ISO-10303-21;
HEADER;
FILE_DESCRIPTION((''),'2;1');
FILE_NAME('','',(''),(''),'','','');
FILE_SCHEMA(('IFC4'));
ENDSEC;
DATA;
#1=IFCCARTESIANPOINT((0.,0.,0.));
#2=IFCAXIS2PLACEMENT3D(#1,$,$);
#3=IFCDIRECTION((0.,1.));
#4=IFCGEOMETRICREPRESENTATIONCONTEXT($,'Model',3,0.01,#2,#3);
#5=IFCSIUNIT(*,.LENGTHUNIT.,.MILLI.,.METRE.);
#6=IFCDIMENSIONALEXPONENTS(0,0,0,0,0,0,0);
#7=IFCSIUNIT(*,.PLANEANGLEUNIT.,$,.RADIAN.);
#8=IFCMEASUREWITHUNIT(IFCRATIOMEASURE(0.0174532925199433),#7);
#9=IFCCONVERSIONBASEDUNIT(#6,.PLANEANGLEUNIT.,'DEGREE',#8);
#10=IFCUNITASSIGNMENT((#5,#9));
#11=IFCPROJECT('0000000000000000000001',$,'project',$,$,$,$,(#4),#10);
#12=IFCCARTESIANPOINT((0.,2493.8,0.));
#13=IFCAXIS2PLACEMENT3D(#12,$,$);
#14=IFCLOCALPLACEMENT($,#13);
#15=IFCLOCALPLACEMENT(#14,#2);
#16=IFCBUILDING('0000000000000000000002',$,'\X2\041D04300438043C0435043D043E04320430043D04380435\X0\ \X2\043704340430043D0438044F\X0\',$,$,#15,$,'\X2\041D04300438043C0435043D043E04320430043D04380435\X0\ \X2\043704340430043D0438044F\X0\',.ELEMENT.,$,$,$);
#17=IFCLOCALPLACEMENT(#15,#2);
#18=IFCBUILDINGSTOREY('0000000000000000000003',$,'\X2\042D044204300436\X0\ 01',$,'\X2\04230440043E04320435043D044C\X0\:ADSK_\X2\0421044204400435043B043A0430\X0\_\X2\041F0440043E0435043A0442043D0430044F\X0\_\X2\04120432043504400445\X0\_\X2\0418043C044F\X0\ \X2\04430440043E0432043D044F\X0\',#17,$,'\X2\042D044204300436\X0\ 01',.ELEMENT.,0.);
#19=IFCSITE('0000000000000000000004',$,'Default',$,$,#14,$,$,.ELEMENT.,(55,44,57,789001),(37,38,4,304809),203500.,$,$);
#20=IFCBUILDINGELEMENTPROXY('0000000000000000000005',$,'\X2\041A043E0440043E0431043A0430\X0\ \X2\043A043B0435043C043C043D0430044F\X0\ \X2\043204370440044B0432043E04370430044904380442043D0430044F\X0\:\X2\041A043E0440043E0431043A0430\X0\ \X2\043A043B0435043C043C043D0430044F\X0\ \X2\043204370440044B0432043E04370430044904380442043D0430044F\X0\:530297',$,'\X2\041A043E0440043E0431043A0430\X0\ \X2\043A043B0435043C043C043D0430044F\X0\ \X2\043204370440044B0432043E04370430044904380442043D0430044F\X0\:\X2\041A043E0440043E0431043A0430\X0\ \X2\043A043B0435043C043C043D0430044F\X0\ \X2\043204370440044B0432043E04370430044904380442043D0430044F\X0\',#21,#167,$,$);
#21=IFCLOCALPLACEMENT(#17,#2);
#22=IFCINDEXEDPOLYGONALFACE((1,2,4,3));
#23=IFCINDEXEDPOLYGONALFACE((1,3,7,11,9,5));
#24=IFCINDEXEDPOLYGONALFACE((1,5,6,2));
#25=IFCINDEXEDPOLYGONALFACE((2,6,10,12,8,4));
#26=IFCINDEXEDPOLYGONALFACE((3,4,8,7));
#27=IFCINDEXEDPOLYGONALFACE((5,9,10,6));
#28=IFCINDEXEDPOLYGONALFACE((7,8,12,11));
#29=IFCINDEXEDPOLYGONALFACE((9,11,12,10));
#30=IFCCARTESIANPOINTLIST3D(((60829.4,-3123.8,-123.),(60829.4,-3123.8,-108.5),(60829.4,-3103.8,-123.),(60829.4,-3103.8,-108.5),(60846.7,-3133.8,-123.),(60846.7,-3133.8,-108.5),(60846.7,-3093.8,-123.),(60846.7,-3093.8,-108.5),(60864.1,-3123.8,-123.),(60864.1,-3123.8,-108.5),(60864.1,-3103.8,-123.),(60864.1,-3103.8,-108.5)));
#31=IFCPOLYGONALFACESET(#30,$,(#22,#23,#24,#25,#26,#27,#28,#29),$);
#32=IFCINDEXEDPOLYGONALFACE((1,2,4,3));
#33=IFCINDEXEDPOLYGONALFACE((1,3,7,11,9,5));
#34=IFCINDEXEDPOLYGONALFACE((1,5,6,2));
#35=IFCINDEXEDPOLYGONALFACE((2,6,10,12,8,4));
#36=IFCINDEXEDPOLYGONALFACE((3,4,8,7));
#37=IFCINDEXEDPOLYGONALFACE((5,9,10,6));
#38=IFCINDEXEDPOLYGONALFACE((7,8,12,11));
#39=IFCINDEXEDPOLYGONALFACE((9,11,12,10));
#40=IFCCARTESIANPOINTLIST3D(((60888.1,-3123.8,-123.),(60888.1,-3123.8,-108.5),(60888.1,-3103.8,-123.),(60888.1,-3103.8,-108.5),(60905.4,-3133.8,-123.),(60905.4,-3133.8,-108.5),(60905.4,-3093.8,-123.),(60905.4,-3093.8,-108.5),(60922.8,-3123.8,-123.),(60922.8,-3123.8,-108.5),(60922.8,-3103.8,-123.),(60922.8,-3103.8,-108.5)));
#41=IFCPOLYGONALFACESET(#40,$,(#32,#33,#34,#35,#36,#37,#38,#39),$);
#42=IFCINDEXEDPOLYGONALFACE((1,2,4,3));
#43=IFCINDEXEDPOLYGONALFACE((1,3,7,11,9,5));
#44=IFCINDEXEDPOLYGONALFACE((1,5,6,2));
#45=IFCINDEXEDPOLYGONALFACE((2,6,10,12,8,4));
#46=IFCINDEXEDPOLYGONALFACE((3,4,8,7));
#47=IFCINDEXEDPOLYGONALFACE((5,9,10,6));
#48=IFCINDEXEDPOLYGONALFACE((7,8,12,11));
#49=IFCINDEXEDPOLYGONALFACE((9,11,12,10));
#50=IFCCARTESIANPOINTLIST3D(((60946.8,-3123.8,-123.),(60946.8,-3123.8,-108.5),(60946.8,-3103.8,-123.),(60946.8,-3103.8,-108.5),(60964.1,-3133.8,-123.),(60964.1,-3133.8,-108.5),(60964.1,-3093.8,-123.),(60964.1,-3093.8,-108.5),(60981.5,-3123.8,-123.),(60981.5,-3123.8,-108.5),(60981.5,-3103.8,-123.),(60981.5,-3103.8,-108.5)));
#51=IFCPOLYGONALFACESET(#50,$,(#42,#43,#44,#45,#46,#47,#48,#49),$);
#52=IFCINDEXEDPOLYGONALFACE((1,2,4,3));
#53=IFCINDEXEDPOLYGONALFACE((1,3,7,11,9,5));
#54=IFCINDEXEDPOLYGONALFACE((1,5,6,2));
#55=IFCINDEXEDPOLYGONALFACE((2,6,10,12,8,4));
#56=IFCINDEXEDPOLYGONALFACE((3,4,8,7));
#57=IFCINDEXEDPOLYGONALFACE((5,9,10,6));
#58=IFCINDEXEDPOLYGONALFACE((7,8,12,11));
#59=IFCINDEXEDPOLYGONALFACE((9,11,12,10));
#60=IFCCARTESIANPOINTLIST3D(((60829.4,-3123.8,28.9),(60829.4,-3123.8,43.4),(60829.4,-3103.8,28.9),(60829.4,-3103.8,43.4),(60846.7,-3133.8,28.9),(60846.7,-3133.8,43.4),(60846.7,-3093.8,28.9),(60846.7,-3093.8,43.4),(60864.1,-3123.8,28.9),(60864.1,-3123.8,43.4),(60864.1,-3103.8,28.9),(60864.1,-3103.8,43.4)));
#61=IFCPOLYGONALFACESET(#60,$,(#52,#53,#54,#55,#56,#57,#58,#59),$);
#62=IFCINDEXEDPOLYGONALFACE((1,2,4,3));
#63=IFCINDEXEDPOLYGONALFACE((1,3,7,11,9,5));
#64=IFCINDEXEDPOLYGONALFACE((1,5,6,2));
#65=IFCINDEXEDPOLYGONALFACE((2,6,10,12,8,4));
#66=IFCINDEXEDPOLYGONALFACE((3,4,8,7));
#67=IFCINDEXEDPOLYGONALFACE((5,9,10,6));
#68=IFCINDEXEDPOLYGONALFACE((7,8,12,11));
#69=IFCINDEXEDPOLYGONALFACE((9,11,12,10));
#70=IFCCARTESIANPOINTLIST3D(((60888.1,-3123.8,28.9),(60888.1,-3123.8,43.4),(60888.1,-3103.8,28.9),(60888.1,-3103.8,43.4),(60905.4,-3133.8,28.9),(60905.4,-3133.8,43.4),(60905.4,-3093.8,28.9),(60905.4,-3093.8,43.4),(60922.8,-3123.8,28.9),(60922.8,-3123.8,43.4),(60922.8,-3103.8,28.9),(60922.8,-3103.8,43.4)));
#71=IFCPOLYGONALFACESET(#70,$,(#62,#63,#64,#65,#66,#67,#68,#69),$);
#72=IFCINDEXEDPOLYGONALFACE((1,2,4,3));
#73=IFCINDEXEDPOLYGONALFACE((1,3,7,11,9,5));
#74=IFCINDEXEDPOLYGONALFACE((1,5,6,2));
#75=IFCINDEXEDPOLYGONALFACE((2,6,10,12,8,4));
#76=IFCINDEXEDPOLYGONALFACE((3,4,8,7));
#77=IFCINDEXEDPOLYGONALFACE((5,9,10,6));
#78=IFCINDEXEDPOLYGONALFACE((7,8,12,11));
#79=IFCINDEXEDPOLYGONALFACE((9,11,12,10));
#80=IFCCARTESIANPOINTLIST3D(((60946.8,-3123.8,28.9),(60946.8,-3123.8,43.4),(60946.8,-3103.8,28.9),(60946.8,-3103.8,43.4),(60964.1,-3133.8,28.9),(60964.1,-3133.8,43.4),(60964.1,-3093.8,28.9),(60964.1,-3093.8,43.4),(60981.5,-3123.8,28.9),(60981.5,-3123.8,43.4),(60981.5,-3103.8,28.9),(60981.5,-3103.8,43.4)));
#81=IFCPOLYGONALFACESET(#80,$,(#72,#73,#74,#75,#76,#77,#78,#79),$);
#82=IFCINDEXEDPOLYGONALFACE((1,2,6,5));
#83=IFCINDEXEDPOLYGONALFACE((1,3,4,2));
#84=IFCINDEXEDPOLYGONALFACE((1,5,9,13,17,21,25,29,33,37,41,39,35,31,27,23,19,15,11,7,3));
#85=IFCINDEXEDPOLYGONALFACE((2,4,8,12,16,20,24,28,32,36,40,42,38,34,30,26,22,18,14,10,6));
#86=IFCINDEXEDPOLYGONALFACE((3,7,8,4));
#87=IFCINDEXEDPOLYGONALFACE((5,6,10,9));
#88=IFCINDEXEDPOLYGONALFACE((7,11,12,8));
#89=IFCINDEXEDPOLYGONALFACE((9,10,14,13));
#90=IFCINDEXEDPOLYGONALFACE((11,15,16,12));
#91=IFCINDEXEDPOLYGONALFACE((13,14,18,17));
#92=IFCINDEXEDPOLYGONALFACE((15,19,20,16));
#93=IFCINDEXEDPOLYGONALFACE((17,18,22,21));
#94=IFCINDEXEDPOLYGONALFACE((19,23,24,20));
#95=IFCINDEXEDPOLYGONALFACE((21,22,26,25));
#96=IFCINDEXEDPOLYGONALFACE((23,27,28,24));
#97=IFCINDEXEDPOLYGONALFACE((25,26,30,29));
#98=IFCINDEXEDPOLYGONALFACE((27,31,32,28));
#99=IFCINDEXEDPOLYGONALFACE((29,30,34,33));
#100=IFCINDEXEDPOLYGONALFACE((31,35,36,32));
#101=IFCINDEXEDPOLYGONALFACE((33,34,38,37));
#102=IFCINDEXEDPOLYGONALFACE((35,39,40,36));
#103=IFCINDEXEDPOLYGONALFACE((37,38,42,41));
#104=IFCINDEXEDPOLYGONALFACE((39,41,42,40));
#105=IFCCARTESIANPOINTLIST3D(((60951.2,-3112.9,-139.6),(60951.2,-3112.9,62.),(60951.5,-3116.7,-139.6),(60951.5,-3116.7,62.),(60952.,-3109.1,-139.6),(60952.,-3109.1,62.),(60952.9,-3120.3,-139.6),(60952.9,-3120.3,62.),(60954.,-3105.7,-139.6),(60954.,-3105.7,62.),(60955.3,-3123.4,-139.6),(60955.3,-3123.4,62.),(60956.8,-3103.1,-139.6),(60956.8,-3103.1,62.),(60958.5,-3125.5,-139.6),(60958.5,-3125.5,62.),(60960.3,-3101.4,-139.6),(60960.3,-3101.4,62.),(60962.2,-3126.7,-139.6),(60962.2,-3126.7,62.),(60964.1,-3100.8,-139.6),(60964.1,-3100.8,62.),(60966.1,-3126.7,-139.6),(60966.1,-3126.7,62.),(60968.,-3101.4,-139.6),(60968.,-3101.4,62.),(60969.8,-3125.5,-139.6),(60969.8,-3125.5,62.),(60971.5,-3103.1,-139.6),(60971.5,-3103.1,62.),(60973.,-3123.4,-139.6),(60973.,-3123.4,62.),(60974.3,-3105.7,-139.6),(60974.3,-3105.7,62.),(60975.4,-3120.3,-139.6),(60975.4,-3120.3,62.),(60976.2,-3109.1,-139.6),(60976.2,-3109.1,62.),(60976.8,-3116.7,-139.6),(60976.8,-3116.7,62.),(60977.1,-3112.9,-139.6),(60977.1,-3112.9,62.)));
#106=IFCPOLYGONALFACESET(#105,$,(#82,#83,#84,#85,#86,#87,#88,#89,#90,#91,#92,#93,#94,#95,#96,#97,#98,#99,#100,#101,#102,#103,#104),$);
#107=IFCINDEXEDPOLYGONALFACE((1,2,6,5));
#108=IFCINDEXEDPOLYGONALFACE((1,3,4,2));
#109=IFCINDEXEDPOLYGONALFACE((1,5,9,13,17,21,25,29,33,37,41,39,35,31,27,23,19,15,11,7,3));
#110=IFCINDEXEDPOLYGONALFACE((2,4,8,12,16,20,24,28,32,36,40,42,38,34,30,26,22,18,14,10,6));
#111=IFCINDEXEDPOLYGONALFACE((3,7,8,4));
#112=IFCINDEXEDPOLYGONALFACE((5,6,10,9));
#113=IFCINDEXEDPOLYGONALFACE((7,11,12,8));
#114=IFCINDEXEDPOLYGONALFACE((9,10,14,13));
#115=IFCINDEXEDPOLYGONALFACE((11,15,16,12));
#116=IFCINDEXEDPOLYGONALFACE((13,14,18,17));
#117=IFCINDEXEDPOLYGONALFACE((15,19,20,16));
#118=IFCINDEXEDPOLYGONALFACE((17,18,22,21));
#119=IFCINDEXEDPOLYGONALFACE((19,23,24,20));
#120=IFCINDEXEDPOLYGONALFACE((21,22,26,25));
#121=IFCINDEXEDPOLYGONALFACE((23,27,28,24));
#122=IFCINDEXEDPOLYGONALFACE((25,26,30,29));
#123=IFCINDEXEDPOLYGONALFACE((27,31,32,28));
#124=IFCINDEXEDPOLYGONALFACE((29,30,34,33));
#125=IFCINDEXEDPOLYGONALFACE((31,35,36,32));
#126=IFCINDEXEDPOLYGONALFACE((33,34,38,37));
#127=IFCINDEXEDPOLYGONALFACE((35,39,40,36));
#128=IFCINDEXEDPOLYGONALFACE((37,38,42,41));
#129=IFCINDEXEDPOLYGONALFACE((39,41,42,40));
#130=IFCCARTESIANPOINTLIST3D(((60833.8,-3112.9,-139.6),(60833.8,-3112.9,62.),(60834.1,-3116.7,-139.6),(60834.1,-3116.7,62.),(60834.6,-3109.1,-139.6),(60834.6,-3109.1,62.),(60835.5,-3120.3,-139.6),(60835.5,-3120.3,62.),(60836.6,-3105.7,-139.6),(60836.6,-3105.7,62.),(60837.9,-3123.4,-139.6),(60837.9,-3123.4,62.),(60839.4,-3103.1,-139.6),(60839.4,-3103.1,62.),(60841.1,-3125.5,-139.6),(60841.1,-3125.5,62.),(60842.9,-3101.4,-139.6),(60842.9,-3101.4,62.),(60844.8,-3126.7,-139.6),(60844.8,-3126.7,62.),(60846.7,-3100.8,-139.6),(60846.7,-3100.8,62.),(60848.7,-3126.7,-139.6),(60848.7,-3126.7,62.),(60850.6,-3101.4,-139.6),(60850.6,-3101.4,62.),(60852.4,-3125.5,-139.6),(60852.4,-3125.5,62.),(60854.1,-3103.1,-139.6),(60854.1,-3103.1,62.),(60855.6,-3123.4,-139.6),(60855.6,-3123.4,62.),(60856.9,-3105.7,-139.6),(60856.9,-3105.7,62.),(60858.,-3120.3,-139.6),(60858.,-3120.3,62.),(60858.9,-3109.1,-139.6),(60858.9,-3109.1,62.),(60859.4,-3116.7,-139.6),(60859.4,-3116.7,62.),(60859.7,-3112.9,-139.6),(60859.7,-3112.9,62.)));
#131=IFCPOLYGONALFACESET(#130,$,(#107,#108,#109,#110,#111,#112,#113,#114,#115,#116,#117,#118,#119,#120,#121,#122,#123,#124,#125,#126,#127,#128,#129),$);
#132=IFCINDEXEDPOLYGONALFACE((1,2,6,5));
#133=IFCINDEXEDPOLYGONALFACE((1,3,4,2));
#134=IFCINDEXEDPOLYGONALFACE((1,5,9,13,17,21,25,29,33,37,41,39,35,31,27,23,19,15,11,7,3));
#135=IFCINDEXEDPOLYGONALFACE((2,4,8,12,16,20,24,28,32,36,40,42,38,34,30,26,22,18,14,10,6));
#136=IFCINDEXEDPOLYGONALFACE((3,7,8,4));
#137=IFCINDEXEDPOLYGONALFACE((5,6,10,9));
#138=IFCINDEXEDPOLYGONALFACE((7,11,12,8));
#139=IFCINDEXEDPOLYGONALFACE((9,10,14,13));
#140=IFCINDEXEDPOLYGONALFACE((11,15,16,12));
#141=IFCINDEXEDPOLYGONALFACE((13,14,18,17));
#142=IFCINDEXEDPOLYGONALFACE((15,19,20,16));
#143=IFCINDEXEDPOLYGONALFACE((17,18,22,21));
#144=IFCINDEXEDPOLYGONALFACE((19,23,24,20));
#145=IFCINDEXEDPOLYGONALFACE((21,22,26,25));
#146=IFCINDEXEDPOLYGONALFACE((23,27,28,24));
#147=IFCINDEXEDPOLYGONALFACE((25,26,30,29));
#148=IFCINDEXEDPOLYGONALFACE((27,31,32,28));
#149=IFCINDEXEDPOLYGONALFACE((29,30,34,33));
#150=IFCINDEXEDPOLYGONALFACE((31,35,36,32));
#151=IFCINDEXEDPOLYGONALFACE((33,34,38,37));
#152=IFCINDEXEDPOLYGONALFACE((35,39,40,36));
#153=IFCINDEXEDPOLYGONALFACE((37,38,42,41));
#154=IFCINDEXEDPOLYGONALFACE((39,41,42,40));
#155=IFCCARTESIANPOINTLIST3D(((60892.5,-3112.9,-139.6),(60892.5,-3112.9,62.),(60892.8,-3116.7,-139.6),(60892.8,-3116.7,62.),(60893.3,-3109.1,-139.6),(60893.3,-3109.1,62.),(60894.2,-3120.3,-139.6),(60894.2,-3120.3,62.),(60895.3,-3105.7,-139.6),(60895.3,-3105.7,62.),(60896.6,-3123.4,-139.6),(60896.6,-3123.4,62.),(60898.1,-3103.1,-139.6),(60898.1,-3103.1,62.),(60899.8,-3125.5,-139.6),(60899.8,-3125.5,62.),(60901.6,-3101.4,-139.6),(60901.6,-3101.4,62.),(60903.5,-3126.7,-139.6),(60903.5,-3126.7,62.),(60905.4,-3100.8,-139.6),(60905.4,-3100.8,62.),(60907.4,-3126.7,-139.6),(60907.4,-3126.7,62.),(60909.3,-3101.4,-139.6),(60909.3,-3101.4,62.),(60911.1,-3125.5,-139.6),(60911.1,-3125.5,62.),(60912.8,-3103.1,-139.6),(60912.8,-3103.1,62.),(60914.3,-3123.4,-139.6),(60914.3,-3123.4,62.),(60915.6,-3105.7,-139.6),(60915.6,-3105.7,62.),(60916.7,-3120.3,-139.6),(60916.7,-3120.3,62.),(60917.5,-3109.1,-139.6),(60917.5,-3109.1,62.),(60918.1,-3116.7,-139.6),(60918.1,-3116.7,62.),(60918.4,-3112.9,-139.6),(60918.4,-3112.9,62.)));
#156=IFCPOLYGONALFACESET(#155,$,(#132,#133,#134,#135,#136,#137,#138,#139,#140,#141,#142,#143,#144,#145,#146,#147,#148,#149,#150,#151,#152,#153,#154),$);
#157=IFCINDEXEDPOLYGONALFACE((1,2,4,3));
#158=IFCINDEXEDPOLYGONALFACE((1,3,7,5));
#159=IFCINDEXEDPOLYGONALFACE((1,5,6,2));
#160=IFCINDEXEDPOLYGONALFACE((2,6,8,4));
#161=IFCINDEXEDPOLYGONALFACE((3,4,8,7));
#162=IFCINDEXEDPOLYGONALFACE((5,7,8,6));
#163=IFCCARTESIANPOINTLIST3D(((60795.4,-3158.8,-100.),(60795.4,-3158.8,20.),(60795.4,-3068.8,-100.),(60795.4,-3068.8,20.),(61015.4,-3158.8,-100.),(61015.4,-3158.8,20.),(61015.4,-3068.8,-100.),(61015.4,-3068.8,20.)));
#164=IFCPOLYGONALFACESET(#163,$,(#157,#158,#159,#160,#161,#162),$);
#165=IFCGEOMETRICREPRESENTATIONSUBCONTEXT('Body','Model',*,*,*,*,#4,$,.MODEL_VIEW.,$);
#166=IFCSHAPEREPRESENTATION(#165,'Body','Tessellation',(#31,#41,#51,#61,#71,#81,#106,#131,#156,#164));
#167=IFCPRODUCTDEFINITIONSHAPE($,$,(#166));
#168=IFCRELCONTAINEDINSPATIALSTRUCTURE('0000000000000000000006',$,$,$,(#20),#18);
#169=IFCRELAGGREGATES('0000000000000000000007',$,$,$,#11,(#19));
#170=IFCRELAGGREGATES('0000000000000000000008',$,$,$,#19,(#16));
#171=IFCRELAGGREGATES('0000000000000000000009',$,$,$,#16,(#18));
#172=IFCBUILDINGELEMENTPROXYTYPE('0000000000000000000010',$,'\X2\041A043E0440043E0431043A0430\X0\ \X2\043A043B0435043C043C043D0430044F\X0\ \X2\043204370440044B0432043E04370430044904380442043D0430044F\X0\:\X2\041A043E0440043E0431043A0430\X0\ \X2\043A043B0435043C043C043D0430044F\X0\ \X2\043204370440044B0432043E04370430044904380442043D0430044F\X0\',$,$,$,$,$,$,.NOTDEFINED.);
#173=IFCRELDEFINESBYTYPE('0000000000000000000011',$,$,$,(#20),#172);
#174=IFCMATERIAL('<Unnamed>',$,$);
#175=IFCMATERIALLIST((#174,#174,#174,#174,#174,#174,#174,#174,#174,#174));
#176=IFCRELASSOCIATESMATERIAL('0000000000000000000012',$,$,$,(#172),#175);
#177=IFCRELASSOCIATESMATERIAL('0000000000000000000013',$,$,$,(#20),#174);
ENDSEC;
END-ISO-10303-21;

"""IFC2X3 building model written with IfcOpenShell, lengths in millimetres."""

from ifc_helpers import new_model, entity, si_unit, converted_unit, direction, frame, frame_2d, origin, place, context, subcontext, project, spatial, polyline, rectangle, circle, outline, extrude, source, transform, mapped, material, material_list, type_object, type_shapes, element, save


model = new_model("IFC2X3")

# Units and contexts
model_context = context("Model", 3, precision=0.01, world=origin(), true_north=direction((0.0, 1.0)))
body_context = subcontext(model_context, "Body", "Model", "MODEL_VIEW")
ifc_project = project(units=[si_unit("LENGTHUNIT", "METRE", prefix="MILLI"), converted_unit("PLANEANGLEUNIT", "DEGREE", entity("IfcRatioMeasure", 0.0174532925199433), si_unit("PLANEANGLEUNIT", "RADIAN"), dimensions=[0, 0, 0, 0, 0, 0, 0])], contexts=[model_context])

# Site, building, storey
site_placement = place(None, frame((0.0, 2493.8, 0.0)))
site = spatial("IfcSite", under=ifc_project, at=site_placement, Name="Default", CompositionType="ELEMENT", RefLatitude=(55, 44, 57, 789001), RefLongitude=(37, 38, 4, 304809), RefElevation=203500.0)
building_placement = place(site_placement, origin())
building = spatial("IfcBuilding", under=site, at=building_placement, Name="Наименование здания", LongName="Наименование здания", CompositionType="ELEMENT")
storey_placement = place(building_placement, origin())
storey = spatial("IfcBuildingStorey", under=building, at=storey_placement, Name="Этаж 01", ObjectType="Уровень:ADSK_Стрелка_Проектная_Вверх_Имя уровня", LongName="Этаж 01", CompositionType="ELEMENT", Elevation=0.0)

# Building element proxy
ifc_material_1 = material(Name="<Unnamed>")
ifc_material_list_1 = material_list([ifc_material_1, ifc_material_1, ifc_material_1, ifc_material_1, ifc_material_1, ifc_material_1, ifc_material_1, ifc_material_1, ifc_material_1, ifc_material_1])
building_element_proxy_type_1 = type_object("IfcBuildingElementProxyType", Name="Коробка клеммная взрывозащитная:Коробка клеммная взрывозащитная", PredefinedType="NOTDEFINED", material=ifc_material_list_1)
shared_shape_1 = source(origin(), body_context, "Body", "SweptSolid", [
    extrude(outline(polyline([(-10.0, -17.3), (10.0, -17.3), (20.0, 0.0), (10.0, 17.3), (-10.0, 17.3), (-20.0, 0.0), (-10.0, -17.3)])), frame((0.0, 58.7, -23.0), z_axis=(0.0, 0.0, 1.0), x_axis=(-1.0, 0.0, 0.0)), (0.0, 0.0, 1.0), 14.4),
    extrude(outline(polyline([(-10.0, -17.3), (10.0, -17.3), (20.0, 0.0), (10.0, 17.3), (-10.0, 17.3), (-20.0, 0.0), (-10.0, -17.3)])), frame((0.0, 0.0, -23.0), z_axis=(0.0, 0.0, 1.0), x_axis=(-1.0, 0.0, 0.0)), (0.0, 0.0, 1.0), 14.4),
    extrude(outline(polyline([(-10.0, -17.3), (10.0, -17.3), (20.0, 0.0), (10.0, 17.3), (-10.0, 17.3), (-20.0, 0.0), (-10.0, -17.3)])), frame((0.0, -58.7, -23.0), z_axis=(0.0, 0.0, 1.0), x_axis=(-1.0, 0.0, 0.0)), (0.0, 0.0, 1.0), 14.4),
    extrude(outline(polyline([(-10.0, -17.3), (10.0, -17.3), (20.0, 0.0), (10.0, 17.3), (-10.0, 17.3), (-20.0, 0.0), (-10.0, -17.3)])), frame((0.0, 58.7, 128.9), z_axis=(0.0, 0.0, 1.0), x_axis=(-1.0, 0.0, 0.0)), (0.0, 0.0, 1.0), 14.4),
    extrude(outline(polyline([(-10.0, -17.3), (10.0, -17.3), (20.0, 0.0), (10.0, 17.3), (-10.0, 17.3), (-20.0, 0.0), (-10.0, -17.3)])), frame((0.0, 0.0, 128.9), z_axis=(0.0, 0.0, 1.0), x_axis=(-1.0, 0.0, 0.0)), (0.0, 0.0, 1.0), 14.4),
    extrude(outline(polyline([(-10.0, -17.3), (10.0, -17.3), (20.0, 0.0), (10.0, 17.3), (-10.0, 17.3), (-20.0, 0.0), (-10.0, -17.3)])), frame((0.0, -58.7, 128.9), z_axis=(0.0, 0.0, 1.0), x_axis=(-1.0, 0.0, 0.0)), (0.0, 0.0, 1.0), 14.4),
    extrude(circle(Radius=13.0, at=frame_2d((0.0, 0.0), x_axis=(1.0, 0.0))), frame((0.0, -58.7, -39.6)), (0.0, 0.0, 1.0), 201.6),
    extrude(circle(Radius=13.0, at=frame_2d((0.0, 0.0), x_axis=(1.0, 0.0))), frame((0.0, 58.7, -39.6)), (0.0, 0.0, 1.0), 201.6),
    extrude(circle(Radius=13.0, at=frame_2d((0.0, 0.0), x_axis=(1.0, 0.0))), frame((0.0, 0.0, -39.6)), (0.0, 0.0, 1.0), 201.6),
    extrude(rectangle(XDim=220.0, YDim=90.0, at=frame_2d((0.0, 0.0), x_axis=(1.0, 0.0))), frame((0.0, 0.0, 0.0), z_axis=(0.0, 0.0, 1.0), x_axis=(0.0, -1.0, 0.0)), (0.0, 0.0, 1.0), 120.0),
])
type_shapes(building_element_proxy_type_1, [shared_shape_1])
for number, where, z_axis, x_axis, name in (
    (1, (60905.4, -3113.8, -100.0), (0.0, 0.0, 1.0), (0.0, 1.0, 0.0), "Коробка клеммная взрывозащитная:Коробка клеммная взрывозащитная:530297"),
):
    element("IfcBuildingElementProxy", number, at=place(storey_placement, frame(where, z_axis=z_axis, x_axis=x_axis)), inside=storey, type_object=building_element_proxy_type_1, material=ifc_material_1, Name=name, ObjectType="Коробка клеммная взрывозащитная:Коробка клеммная взрывозащитная", context=body_context, shape_type="MappedRepresentation", body=[
        mapped(shared_shape_1, transform((0.0, 0.0, 0.0), scale=1.0)),
    ])

save(model, "model.ifc")
